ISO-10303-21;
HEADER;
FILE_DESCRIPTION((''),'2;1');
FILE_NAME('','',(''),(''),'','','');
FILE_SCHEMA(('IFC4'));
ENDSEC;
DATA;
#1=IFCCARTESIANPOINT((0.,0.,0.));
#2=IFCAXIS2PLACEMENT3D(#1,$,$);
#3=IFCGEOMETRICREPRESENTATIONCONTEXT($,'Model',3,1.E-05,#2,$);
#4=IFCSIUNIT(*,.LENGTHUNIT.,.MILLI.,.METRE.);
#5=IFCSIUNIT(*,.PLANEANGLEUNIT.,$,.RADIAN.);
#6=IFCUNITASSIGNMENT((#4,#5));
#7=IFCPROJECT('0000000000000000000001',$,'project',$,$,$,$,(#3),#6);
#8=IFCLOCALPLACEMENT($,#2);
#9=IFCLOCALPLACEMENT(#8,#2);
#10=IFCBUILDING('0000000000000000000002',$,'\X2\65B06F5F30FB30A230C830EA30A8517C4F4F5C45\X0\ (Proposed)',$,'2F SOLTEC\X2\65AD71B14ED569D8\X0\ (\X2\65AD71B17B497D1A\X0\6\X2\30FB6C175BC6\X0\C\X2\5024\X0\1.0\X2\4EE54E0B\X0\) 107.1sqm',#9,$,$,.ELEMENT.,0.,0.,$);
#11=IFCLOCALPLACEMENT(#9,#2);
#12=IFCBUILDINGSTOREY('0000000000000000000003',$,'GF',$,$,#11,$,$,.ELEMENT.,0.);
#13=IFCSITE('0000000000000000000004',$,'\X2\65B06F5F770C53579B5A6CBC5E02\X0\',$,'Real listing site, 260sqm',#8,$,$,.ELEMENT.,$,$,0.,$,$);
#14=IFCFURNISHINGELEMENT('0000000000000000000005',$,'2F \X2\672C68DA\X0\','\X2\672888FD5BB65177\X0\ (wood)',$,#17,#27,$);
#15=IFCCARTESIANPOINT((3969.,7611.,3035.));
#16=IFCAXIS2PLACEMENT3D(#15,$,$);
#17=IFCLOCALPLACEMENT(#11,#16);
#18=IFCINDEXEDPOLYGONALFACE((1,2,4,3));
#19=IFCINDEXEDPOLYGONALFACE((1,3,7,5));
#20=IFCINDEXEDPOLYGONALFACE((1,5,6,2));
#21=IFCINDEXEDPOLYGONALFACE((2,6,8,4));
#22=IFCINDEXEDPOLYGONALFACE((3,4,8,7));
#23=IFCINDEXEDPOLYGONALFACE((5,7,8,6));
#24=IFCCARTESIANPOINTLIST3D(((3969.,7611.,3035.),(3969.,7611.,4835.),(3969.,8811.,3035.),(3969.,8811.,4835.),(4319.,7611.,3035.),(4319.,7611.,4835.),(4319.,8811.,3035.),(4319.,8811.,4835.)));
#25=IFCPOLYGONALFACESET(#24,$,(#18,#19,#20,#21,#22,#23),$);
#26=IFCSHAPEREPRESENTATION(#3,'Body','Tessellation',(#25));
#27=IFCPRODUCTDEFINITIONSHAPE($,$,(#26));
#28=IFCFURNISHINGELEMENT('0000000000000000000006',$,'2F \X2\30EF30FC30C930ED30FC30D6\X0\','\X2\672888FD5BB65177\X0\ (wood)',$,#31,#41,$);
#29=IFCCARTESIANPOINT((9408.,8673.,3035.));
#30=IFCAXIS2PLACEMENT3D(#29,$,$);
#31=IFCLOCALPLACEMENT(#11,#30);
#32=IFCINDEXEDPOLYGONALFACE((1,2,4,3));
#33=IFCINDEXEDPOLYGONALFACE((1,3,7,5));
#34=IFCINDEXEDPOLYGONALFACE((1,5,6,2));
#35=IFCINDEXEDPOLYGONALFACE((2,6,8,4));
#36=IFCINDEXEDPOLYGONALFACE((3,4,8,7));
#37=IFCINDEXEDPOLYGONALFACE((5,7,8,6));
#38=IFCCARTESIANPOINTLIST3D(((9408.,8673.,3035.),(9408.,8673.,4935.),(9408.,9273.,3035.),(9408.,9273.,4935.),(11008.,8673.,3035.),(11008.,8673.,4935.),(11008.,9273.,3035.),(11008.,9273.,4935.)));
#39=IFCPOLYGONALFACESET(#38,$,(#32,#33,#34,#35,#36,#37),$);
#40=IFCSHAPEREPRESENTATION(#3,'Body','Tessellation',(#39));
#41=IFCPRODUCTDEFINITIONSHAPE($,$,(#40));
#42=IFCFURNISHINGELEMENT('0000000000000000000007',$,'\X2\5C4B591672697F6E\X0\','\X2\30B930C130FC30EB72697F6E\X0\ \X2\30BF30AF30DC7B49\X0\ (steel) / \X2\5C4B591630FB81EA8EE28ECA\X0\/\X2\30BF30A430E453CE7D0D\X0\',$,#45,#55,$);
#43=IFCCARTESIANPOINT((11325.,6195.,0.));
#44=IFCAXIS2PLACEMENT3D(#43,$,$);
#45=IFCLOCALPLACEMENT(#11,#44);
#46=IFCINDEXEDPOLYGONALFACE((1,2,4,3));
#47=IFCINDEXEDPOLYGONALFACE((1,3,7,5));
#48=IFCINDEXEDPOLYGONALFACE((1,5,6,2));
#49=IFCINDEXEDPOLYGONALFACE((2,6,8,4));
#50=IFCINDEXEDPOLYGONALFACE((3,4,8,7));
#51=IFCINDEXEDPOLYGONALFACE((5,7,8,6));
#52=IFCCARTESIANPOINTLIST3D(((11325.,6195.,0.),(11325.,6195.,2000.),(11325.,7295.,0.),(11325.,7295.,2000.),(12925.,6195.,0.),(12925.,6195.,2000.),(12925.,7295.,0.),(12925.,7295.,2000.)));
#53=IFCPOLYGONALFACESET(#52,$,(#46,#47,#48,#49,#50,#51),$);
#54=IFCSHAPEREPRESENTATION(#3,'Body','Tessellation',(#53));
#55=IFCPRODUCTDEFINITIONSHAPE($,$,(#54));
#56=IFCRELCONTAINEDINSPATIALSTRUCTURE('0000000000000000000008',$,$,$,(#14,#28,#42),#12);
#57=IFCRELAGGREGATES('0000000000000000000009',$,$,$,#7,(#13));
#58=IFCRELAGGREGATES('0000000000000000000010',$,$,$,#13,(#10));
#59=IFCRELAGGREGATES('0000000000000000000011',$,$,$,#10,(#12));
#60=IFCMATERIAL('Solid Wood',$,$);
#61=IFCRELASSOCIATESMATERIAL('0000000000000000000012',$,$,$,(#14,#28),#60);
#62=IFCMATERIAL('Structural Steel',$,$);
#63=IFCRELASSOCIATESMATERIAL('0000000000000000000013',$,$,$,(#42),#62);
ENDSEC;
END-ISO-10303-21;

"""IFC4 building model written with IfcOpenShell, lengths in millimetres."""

from ifc_helpers import new_model, si_unit, frame, frame_2d, origin, place, context, project, spatial, rectangle, extrude, material, element, save


model = new_model("IFC4")

# Units and contexts
model_context = context("Model", 3, precision=1e-05, world=origin())
ifc_project = project(units=[si_unit("LENGTHUNIT", "METRE", prefix="MILLI"), si_unit("PLANEANGLEUNIT", "RADIAN")], contexts=[model_context])

# Site, building, storey
site_placement = place(None, origin())
site = spatial("IfcSite", under=ifc_project, at=site_placement, Name="新潟県南魚沼市", ObjectType="Real listing site, 260sqm", CompositionType="ELEMENT", RefElevation=0.0)
building_placement = place(site_placement, origin())
building = spatial("IfcBuilding", under=site, at=building_placement, Name="新潟・アトリエ兼住居 (Proposed)", ObjectType="2F SOLTEC断熱仕様 (断熱等級6・気密C値1.0以下) 107.1sqm", CompositionType="ELEMENT", ElevationOfRefHeight=0.0, ElevationOfTerrain=0.0)
storey_placement = place(building_placement, origin())
storey = spatial("IfcBuildingStorey", under=building, at=storey_placement, Name="GF", CompositionType="ELEMENT", Elevation=0.0)

# Shared definitions
ifc_material_1 = material(Name="Solid Wood")

# Shared definitions
ifc_material_2 = material(Name="Structural Steel")

# Furnishing elements
furnishing_1_placement = place(storey_placement, frame((3969.0, 7611.0, 3035.0)))
element("IfcFurnishingElement", 1, at=furnishing_1_placement, inside=storey, material=ifc_material_1, Name="2F 本棚", Description="木製家具 (wood)", context=model_context, shape_type="SweptSolid", body=[
    extrude(rectangle(XDim=350.0, YDim=1200.0, at=frame_2d((175.0, 600.0))), frame((3969.0, 7611.0, 3035.0)), (0.0, 0.0, 1.0), 1800.0),
])
furnishing_2_placement = place(storey_placement, frame((9408.0, 8673.0, 3035.0)))
element("IfcFurnishingElement", 2, at=furnishing_2_placement, inside=storey, material=ifc_material_1, Name="2F ワードローブ", Description="木製家具 (wood)", context=model_context, shape_type="SweptSolid", body=[
    extrude(rectangle(XDim=1600.0, YDim=600.0, at=frame_2d((800.0, 300.0))), frame((9408.0, 8673.0, 3035.0)), (0.0, 0.0, 1.0), 1900.0),
])
furnishing_3_placement = place(storey_placement, frame((11325.0, 6195.0, 0.0)))
element("IfcFurnishingElement", 3, at=furnishing_3_placement, inside=storey, material=ifc_material_2, Name="屋外物置", Description="スチール物置 タクボ等 (steel) / 屋外・自転車/タイヤ収納", context=model_context, shape_type="SweptSolid", body=[
    extrude(rectangle(XDim=1600.0, YDim=1100.0, at=frame_2d((800.0, 550.0))), frame((11325.0, 6195.0, 0.0)), (0.0, 0.0, 1.0), 2000.0),
])

save(model, "model.ifc")
